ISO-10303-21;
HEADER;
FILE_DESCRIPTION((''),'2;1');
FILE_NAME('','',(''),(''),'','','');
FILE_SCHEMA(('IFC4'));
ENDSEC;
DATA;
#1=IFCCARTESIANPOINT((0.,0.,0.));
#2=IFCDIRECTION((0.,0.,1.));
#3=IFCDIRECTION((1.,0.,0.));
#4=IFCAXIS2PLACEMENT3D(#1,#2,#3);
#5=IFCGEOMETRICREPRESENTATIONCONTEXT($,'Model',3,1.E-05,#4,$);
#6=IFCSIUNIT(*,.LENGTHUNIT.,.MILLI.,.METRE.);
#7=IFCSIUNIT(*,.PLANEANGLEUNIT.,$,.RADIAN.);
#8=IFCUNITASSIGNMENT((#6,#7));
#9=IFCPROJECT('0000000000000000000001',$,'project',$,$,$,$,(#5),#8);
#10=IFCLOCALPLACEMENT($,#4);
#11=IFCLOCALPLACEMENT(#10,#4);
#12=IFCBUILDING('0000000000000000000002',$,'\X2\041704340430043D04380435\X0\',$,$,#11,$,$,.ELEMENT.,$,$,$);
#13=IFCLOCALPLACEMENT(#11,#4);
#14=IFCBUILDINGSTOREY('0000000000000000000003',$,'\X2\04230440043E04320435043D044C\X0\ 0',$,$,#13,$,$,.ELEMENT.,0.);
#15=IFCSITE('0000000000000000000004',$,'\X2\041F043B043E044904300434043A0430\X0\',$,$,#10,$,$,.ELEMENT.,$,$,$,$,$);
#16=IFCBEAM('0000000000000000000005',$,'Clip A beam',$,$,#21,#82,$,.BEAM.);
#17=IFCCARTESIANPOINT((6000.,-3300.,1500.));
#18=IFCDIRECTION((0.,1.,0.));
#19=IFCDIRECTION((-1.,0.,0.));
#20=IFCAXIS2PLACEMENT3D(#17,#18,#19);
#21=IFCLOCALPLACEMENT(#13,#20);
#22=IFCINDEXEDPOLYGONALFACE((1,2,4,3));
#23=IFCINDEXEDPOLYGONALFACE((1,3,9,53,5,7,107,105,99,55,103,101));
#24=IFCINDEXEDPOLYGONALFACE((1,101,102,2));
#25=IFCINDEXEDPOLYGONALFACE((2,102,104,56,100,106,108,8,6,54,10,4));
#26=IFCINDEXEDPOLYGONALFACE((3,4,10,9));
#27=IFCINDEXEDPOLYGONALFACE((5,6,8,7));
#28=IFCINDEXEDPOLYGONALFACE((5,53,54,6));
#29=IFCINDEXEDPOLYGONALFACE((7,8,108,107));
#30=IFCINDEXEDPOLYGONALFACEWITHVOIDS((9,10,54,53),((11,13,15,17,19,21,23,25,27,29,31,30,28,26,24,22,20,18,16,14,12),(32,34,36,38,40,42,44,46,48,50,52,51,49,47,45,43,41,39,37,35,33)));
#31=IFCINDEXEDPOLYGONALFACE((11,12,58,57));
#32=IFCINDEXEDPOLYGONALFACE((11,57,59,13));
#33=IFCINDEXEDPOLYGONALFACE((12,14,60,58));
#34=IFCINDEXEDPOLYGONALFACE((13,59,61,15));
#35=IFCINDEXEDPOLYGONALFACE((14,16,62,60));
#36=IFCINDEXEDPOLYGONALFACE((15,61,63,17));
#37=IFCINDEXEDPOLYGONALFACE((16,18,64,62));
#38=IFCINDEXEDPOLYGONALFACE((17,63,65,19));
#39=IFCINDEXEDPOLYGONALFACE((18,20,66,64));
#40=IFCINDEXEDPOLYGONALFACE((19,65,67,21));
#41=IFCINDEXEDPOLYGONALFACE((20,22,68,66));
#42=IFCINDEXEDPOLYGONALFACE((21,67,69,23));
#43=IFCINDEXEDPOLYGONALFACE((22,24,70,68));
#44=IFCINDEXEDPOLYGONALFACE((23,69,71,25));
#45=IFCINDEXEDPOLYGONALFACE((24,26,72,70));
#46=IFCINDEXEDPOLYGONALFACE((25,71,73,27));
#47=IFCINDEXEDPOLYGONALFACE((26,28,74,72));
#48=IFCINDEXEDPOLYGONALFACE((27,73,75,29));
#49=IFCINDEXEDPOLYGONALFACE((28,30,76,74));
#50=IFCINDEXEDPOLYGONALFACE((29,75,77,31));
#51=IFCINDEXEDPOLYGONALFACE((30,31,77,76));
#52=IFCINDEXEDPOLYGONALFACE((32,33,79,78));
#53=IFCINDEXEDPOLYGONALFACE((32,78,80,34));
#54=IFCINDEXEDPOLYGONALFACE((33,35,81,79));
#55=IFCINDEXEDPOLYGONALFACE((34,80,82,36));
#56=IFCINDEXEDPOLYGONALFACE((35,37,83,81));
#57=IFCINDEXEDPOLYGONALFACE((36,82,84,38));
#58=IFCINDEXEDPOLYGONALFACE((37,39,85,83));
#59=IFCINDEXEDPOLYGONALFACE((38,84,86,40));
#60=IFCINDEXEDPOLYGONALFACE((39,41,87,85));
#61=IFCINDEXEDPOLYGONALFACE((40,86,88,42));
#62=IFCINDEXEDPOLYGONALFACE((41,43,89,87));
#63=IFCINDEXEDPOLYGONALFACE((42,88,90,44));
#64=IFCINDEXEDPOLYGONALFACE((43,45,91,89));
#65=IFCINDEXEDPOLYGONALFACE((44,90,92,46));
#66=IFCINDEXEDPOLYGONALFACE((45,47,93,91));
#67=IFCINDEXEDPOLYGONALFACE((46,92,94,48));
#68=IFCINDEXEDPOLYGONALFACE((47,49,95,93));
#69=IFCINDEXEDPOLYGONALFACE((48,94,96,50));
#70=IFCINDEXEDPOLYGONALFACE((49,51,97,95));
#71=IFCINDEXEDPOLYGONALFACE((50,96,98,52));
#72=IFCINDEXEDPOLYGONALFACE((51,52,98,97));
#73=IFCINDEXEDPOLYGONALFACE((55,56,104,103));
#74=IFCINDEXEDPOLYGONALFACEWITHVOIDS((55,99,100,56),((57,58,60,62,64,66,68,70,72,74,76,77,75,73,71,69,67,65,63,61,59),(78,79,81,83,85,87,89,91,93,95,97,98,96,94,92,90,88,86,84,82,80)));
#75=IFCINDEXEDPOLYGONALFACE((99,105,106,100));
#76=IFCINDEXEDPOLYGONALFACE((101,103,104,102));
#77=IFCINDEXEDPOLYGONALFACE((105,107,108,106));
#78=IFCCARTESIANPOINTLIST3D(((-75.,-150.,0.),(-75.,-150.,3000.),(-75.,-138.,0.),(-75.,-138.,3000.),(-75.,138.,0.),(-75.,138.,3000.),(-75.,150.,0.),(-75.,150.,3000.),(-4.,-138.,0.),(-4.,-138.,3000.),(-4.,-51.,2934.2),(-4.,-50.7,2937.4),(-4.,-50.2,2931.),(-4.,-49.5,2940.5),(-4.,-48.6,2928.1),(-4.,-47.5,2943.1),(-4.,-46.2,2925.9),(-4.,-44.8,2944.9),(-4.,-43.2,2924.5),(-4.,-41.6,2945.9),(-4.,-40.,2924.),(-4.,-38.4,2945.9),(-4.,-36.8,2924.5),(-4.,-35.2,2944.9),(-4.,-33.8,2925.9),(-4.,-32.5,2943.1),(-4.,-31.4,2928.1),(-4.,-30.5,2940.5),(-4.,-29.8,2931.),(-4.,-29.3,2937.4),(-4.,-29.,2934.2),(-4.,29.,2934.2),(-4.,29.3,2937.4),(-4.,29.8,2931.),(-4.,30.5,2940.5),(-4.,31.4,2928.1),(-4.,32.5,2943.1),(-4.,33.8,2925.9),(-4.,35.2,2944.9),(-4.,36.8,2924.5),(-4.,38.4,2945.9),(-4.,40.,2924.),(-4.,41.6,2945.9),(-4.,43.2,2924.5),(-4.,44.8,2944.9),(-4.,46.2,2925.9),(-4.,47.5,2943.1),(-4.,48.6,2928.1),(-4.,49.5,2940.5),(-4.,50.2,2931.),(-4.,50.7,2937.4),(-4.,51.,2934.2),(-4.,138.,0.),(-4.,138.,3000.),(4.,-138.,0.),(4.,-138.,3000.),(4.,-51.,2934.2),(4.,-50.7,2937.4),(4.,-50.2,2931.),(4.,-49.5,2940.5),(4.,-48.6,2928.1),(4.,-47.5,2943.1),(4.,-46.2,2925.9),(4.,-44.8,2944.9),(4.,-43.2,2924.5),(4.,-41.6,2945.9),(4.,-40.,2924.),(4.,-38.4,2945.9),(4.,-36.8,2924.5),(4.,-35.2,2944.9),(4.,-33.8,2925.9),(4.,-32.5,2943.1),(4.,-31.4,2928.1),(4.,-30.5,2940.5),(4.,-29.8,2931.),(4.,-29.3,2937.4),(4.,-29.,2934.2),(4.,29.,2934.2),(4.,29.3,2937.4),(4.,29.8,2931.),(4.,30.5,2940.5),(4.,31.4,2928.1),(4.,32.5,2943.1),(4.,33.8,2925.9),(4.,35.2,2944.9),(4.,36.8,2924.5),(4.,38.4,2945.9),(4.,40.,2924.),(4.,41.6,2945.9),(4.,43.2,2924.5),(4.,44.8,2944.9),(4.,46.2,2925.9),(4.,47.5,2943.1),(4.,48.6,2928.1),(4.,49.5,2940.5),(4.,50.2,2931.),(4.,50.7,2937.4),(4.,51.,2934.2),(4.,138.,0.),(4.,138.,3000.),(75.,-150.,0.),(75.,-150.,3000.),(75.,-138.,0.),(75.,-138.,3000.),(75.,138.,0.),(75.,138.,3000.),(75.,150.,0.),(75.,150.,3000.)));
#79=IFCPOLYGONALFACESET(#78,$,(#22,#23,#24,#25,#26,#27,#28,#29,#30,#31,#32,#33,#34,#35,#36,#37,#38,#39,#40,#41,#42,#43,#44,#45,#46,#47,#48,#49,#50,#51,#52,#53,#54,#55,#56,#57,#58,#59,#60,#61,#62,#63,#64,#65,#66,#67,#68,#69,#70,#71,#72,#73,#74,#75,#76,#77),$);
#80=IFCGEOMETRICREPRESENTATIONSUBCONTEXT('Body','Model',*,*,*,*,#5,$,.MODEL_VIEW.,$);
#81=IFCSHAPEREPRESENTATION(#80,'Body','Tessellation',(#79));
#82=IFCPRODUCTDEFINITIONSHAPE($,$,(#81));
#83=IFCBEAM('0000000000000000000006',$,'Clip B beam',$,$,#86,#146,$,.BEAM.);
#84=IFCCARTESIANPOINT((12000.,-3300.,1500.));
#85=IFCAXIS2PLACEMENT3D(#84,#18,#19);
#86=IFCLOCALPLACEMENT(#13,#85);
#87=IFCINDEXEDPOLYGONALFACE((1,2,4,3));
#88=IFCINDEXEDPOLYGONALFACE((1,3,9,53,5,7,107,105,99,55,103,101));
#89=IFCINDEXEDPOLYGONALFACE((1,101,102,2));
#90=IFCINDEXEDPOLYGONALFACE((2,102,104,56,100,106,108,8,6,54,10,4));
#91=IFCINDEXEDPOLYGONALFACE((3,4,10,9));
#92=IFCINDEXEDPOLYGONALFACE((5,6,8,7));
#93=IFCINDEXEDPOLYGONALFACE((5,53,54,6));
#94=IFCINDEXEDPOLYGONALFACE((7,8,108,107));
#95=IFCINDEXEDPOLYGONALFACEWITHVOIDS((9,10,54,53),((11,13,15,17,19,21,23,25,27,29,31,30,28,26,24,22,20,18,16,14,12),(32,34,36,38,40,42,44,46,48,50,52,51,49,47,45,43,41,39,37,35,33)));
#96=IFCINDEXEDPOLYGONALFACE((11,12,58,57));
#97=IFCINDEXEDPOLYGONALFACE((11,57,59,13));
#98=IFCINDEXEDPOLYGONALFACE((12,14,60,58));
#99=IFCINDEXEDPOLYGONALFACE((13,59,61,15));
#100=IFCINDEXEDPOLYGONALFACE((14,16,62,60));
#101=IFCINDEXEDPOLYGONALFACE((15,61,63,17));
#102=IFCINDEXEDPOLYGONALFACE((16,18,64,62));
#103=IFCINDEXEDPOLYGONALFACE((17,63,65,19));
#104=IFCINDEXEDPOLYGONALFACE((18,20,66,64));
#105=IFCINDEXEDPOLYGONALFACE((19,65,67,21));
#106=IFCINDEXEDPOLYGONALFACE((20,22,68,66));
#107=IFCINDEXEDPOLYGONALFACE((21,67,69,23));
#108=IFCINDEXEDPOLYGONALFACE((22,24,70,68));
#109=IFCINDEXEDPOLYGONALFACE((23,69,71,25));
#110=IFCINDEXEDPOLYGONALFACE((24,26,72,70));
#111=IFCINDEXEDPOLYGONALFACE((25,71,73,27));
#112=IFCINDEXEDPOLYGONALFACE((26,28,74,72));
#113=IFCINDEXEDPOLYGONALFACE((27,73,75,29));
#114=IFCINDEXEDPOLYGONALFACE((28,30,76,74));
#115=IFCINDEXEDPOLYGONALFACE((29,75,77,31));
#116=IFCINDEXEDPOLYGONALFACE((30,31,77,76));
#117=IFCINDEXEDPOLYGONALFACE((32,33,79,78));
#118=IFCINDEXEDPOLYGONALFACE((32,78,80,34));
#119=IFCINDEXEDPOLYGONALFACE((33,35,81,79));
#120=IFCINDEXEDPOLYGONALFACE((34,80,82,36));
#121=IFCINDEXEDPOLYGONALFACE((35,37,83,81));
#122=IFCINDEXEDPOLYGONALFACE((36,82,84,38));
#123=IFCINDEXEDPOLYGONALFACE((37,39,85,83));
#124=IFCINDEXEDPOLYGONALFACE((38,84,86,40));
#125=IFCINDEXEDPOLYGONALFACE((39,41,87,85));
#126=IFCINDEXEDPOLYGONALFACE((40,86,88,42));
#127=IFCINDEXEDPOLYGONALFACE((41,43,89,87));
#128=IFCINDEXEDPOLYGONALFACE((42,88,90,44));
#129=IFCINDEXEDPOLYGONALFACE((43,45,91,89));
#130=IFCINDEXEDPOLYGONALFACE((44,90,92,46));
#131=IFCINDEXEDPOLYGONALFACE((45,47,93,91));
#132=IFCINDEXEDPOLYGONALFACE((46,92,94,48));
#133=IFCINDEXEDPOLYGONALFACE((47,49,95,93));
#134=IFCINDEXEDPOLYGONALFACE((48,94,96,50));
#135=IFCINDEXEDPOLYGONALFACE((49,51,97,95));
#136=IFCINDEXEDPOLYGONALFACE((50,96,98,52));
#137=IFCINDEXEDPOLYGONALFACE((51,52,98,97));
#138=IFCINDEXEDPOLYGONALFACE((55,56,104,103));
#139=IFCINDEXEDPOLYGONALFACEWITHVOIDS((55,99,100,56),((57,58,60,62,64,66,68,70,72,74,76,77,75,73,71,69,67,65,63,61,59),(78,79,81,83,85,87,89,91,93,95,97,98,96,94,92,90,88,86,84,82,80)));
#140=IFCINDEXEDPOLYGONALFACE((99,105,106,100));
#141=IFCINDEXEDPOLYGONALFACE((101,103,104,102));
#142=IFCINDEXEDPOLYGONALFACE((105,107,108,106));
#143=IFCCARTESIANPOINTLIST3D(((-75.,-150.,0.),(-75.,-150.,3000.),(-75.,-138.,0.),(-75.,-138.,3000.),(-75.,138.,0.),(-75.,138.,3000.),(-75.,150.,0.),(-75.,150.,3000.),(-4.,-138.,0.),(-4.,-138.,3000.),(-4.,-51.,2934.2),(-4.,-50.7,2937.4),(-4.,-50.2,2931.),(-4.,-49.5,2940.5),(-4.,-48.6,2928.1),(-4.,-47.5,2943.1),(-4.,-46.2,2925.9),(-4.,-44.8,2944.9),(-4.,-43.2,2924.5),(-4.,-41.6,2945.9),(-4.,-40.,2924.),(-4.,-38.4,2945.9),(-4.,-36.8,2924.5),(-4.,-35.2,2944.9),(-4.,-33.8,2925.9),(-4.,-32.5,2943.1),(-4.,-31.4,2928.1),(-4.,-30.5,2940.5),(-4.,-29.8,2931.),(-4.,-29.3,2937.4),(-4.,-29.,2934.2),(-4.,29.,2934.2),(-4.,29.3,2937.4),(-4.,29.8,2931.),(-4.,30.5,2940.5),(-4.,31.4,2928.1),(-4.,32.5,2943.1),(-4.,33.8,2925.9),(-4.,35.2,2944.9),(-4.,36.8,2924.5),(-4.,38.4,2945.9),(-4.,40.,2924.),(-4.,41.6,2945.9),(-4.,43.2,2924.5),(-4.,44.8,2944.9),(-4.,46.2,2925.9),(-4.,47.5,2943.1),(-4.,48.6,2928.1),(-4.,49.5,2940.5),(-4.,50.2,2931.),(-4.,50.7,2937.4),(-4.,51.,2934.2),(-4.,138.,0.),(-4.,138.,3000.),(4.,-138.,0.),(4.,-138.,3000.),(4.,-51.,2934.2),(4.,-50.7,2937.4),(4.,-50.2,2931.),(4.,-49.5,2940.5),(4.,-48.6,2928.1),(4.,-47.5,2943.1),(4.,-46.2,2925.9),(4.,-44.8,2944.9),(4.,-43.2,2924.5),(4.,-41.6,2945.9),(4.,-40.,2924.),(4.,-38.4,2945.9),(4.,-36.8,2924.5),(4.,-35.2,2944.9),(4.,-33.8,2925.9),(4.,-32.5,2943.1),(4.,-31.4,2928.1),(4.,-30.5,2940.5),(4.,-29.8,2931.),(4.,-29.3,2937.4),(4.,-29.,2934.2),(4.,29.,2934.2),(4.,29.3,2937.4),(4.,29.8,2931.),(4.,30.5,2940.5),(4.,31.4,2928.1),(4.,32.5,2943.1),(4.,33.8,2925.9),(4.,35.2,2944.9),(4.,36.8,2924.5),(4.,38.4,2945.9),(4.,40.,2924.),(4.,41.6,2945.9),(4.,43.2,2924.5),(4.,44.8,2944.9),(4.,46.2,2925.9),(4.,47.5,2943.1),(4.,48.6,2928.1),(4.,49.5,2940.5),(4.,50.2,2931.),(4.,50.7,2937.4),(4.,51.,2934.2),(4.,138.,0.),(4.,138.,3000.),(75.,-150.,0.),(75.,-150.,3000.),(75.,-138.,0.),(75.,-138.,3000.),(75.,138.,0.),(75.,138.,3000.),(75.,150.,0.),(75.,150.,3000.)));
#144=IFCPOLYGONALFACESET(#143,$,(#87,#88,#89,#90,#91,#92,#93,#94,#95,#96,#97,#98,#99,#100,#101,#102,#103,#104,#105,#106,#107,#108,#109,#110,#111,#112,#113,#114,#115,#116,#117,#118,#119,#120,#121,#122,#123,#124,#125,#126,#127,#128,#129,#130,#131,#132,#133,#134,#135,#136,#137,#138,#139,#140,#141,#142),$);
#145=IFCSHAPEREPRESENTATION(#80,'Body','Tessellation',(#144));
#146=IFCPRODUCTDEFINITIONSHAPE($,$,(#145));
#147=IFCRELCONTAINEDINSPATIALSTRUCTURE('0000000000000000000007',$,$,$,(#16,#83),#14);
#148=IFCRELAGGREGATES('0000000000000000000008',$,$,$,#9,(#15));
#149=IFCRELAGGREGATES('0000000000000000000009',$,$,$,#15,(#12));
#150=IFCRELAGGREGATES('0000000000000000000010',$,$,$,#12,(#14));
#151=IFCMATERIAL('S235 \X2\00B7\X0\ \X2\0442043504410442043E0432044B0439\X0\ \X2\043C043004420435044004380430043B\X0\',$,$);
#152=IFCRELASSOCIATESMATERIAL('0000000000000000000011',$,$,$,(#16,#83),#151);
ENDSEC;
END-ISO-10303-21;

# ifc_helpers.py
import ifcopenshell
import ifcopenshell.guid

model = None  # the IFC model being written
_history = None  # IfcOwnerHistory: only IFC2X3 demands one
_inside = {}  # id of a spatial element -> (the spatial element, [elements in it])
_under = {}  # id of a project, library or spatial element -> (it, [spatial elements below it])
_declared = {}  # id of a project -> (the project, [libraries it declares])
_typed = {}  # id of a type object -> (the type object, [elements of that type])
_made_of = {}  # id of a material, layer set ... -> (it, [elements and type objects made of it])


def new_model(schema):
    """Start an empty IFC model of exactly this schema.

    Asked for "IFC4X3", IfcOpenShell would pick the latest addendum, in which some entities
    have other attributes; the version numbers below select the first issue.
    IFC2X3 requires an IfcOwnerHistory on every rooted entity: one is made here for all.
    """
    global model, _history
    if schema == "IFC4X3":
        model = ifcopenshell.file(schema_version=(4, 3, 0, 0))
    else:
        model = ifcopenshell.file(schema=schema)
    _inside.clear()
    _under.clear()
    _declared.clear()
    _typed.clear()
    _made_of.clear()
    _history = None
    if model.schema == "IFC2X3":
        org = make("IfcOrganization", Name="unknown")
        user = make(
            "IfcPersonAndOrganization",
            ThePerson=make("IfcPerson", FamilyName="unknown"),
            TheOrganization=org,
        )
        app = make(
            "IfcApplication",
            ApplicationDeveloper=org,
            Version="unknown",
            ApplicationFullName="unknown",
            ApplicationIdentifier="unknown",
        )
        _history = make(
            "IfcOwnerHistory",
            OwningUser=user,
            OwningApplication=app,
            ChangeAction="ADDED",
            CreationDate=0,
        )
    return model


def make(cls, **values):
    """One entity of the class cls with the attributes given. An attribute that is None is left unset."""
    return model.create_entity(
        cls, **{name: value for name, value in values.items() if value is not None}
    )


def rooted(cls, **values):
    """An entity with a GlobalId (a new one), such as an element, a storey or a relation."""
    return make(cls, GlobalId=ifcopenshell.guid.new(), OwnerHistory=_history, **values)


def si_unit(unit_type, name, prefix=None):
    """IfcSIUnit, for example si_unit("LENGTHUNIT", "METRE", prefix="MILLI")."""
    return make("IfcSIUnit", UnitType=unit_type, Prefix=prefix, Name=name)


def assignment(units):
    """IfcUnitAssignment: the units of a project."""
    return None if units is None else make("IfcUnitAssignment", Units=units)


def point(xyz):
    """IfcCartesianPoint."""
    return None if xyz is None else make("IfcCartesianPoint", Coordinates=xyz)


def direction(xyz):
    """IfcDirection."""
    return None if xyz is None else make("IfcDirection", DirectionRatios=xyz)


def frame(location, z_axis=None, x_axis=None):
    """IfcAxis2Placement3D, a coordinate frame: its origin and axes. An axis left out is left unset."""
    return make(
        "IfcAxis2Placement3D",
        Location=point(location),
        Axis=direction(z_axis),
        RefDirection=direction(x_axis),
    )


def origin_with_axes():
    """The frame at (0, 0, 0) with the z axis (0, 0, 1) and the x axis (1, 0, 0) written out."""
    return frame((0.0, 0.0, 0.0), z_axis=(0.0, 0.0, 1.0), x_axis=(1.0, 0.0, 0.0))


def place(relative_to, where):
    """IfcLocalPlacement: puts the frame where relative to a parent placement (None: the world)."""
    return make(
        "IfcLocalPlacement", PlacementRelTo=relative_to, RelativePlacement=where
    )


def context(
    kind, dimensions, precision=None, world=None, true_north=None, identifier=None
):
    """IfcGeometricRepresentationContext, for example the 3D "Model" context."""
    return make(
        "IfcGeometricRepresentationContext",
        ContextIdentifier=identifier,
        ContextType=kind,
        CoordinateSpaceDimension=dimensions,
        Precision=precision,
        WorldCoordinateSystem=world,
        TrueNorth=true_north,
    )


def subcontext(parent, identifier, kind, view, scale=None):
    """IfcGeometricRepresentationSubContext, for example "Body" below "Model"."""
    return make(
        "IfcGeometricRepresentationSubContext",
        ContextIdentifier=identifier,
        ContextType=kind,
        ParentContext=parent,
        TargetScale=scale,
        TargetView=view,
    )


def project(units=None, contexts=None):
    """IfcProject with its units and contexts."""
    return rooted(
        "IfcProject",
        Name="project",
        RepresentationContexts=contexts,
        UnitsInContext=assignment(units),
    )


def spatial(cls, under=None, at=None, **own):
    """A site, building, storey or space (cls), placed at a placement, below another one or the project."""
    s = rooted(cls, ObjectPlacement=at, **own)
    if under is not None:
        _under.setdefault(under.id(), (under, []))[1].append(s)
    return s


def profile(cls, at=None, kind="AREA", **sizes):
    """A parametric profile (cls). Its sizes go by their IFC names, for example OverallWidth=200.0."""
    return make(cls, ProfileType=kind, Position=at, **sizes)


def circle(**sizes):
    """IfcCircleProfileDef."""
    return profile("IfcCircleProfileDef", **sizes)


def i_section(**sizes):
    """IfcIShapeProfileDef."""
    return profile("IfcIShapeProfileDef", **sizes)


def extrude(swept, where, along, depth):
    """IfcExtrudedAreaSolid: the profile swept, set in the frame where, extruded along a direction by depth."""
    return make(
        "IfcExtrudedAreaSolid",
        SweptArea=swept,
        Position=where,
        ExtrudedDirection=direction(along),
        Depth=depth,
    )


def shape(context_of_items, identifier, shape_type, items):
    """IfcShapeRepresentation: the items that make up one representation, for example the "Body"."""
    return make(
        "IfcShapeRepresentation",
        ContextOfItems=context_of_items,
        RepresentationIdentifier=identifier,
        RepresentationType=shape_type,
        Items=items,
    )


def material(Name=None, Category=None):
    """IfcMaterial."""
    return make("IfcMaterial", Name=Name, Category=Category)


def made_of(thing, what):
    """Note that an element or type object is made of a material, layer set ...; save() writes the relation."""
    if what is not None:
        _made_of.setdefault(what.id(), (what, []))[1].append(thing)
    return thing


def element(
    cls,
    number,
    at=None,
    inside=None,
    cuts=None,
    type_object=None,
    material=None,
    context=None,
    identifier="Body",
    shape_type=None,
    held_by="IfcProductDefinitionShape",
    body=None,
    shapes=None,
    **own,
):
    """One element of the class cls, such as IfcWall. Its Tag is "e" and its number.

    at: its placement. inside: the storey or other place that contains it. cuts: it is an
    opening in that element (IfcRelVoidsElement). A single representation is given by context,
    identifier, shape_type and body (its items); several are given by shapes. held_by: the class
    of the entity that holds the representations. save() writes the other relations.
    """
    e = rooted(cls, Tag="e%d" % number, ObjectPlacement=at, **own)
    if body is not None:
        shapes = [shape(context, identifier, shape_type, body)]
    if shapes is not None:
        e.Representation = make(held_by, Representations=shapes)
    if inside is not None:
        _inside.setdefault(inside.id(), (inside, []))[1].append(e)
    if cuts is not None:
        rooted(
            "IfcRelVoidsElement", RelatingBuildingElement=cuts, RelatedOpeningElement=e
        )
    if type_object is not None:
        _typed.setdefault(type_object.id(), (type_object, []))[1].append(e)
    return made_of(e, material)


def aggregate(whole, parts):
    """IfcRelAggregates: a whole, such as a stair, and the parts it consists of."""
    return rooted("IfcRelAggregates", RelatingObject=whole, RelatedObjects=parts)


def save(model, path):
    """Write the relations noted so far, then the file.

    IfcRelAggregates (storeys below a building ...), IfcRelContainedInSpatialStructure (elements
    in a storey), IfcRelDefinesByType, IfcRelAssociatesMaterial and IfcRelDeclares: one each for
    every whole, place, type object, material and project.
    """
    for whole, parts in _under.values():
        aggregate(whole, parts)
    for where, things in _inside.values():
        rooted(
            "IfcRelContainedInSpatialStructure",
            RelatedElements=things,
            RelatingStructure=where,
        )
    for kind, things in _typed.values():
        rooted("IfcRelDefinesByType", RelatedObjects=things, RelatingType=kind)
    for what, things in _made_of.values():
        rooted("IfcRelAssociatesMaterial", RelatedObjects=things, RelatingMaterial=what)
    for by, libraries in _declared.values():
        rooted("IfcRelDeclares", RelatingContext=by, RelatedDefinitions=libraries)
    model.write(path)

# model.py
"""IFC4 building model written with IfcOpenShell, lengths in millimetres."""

from ifc_helpers import new_model, si_unit, frame, origin_with_axes, place, context, subcontext, project, spatial, circle, i_section, extrude, material, element, save


model = new_model("IFC4")

# Units and contexts
model_context = context("Model", 3, precision=1e-05, world=origin_with_axes())
body_context = subcontext(model_context, "Body", "Model", "MODEL_VIEW")
ifc_project = project(units=[si_unit("LENGTHUNIT", "METRE", prefix="MILLI"), si_unit("PLANEANGLEUNIT", "RADIAN")], contexts=[model_context])

# Site, building, storey
site_placement = place(None, origin_with_axes())
site = spatial("IfcSite", under=ifc_project, at=site_placement, Name="Площадка", CompositionType="ELEMENT")
building_placement = place(site_placement, origin_with_axes())
building = spatial("IfcBuilding", under=site, at=building_placement, Name="Здание", CompositionType="ELEMENT")
storey_placement = place(building_placement, origin_with_axes())
storey = spatial("IfcBuildingStorey", under=building, at=storey_placement, Name="Уровень 0", CompositionType="ELEMENT", Elevation=0.0)

# Shared definitions
ifc_material = material(Name="S235 · тестовый материал")

# Beam, openings
beam_1_placement = place(storey_placement, frame((6000.0, -3300.0, 1500.0), z_axis=(0.0, 1.0, 0.0), x_axis=(-1.0, 0.0, 0.0)))
beam_1 = element("IfcBeam", 1, at=beam_1_placement, inside=storey, material=ifc_material, Name="Clip A beam", PredefinedType="BEAM", context=body_context, shape_type="SweptSolid", body=[
    extrude(i_section(OverallWidth=150.0, OverallDepth=300.0, WebThickness=8.0, FlangeThickness=12.0), origin_with_axes(), (0.0, 0.0, 1.0), 3000.0),
])
opening_1_placement = place(beam_1_placement, frame((25.0, 40.0, 2935.0), z_axis=(-1.0, 0.0, 0.0), x_axis=(0.0, 0.0, -1.0)))
element("IfcOpeningElement", 2, at=opening_1_placement, cuts=beam_1, PredefinedType="OPENING", context=body_context, shape_type="SweptSolid", body=[
    extrude(circle(Radius=11.0), origin_with_axes(), (0.0, 0.0, 1.0), 30.0),
])
opening_2_placement = place(beam_1_placement, frame((25.0, -40.0, 2935.0), z_axis=(-1.0, 0.0, 0.0), x_axis=(0.0, 0.0, -1.0)))
element("IfcOpeningElement", 3, at=opening_2_placement, cuts=beam_1, PredefinedType="OPENING", context=body_context, shape_type="SweptSolid", body=[
    extrude(circle(Radius=11.0), origin_with_axes(), (0.0, 0.0, 1.0), 30.0),
])

# Beam, openings
beam_2_placement = place(storey_placement, frame((12000.0, -3300.0, 1500.0), z_axis=(0.0, 1.0, 0.0), x_axis=(-1.0, 0.0, 0.0)))
beam_2 = element("IfcBeam", 4, at=beam_2_placement, inside=storey, material=ifc_material, Name="Clip B beam", PredefinedType="BEAM", context=body_context, shape_type="SweptSolid", body=[
    extrude(i_section(OverallWidth=150.0, OverallDepth=300.0, WebThickness=8.0, FlangeThickness=12.0), origin_with_axes(), (0.0, 0.0, 1.0), 3000.0),
])
opening_3_placement = place(beam_2_placement, frame((25.0, 40.0, 2935.0), z_axis=(-1.0, 0.0, 0.0), x_axis=(0.0, 0.0, -1.0)))
element("IfcOpeningElement", 5, at=opening_3_placement, cuts=beam_2, PredefinedType="OPENING", context=body_context, shape_type="SweptSolid", body=[
    extrude(circle(Radius=11.0), origin_with_axes(), (0.0, 0.0, 1.0), 30.0),
])
opening_4_placement = place(beam_2_placement, frame((25.0, -40.0, 2935.0), z_axis=(-1.0, 0.0, 0.0), x_axis=(0.0, 0.0, -1.0)))
element("IfcOpeningElement", 6, at=opening_4_placement, cuts=beam_2, PredefinedType="OPENING", context=body_context, shape_type="SweptSolid", body=[
    extrude(circle(Radius=11.0), origin_with_axes(), (0.0, 0.0, 1.0), 30.0),
])

save(model, "model.ifc")
